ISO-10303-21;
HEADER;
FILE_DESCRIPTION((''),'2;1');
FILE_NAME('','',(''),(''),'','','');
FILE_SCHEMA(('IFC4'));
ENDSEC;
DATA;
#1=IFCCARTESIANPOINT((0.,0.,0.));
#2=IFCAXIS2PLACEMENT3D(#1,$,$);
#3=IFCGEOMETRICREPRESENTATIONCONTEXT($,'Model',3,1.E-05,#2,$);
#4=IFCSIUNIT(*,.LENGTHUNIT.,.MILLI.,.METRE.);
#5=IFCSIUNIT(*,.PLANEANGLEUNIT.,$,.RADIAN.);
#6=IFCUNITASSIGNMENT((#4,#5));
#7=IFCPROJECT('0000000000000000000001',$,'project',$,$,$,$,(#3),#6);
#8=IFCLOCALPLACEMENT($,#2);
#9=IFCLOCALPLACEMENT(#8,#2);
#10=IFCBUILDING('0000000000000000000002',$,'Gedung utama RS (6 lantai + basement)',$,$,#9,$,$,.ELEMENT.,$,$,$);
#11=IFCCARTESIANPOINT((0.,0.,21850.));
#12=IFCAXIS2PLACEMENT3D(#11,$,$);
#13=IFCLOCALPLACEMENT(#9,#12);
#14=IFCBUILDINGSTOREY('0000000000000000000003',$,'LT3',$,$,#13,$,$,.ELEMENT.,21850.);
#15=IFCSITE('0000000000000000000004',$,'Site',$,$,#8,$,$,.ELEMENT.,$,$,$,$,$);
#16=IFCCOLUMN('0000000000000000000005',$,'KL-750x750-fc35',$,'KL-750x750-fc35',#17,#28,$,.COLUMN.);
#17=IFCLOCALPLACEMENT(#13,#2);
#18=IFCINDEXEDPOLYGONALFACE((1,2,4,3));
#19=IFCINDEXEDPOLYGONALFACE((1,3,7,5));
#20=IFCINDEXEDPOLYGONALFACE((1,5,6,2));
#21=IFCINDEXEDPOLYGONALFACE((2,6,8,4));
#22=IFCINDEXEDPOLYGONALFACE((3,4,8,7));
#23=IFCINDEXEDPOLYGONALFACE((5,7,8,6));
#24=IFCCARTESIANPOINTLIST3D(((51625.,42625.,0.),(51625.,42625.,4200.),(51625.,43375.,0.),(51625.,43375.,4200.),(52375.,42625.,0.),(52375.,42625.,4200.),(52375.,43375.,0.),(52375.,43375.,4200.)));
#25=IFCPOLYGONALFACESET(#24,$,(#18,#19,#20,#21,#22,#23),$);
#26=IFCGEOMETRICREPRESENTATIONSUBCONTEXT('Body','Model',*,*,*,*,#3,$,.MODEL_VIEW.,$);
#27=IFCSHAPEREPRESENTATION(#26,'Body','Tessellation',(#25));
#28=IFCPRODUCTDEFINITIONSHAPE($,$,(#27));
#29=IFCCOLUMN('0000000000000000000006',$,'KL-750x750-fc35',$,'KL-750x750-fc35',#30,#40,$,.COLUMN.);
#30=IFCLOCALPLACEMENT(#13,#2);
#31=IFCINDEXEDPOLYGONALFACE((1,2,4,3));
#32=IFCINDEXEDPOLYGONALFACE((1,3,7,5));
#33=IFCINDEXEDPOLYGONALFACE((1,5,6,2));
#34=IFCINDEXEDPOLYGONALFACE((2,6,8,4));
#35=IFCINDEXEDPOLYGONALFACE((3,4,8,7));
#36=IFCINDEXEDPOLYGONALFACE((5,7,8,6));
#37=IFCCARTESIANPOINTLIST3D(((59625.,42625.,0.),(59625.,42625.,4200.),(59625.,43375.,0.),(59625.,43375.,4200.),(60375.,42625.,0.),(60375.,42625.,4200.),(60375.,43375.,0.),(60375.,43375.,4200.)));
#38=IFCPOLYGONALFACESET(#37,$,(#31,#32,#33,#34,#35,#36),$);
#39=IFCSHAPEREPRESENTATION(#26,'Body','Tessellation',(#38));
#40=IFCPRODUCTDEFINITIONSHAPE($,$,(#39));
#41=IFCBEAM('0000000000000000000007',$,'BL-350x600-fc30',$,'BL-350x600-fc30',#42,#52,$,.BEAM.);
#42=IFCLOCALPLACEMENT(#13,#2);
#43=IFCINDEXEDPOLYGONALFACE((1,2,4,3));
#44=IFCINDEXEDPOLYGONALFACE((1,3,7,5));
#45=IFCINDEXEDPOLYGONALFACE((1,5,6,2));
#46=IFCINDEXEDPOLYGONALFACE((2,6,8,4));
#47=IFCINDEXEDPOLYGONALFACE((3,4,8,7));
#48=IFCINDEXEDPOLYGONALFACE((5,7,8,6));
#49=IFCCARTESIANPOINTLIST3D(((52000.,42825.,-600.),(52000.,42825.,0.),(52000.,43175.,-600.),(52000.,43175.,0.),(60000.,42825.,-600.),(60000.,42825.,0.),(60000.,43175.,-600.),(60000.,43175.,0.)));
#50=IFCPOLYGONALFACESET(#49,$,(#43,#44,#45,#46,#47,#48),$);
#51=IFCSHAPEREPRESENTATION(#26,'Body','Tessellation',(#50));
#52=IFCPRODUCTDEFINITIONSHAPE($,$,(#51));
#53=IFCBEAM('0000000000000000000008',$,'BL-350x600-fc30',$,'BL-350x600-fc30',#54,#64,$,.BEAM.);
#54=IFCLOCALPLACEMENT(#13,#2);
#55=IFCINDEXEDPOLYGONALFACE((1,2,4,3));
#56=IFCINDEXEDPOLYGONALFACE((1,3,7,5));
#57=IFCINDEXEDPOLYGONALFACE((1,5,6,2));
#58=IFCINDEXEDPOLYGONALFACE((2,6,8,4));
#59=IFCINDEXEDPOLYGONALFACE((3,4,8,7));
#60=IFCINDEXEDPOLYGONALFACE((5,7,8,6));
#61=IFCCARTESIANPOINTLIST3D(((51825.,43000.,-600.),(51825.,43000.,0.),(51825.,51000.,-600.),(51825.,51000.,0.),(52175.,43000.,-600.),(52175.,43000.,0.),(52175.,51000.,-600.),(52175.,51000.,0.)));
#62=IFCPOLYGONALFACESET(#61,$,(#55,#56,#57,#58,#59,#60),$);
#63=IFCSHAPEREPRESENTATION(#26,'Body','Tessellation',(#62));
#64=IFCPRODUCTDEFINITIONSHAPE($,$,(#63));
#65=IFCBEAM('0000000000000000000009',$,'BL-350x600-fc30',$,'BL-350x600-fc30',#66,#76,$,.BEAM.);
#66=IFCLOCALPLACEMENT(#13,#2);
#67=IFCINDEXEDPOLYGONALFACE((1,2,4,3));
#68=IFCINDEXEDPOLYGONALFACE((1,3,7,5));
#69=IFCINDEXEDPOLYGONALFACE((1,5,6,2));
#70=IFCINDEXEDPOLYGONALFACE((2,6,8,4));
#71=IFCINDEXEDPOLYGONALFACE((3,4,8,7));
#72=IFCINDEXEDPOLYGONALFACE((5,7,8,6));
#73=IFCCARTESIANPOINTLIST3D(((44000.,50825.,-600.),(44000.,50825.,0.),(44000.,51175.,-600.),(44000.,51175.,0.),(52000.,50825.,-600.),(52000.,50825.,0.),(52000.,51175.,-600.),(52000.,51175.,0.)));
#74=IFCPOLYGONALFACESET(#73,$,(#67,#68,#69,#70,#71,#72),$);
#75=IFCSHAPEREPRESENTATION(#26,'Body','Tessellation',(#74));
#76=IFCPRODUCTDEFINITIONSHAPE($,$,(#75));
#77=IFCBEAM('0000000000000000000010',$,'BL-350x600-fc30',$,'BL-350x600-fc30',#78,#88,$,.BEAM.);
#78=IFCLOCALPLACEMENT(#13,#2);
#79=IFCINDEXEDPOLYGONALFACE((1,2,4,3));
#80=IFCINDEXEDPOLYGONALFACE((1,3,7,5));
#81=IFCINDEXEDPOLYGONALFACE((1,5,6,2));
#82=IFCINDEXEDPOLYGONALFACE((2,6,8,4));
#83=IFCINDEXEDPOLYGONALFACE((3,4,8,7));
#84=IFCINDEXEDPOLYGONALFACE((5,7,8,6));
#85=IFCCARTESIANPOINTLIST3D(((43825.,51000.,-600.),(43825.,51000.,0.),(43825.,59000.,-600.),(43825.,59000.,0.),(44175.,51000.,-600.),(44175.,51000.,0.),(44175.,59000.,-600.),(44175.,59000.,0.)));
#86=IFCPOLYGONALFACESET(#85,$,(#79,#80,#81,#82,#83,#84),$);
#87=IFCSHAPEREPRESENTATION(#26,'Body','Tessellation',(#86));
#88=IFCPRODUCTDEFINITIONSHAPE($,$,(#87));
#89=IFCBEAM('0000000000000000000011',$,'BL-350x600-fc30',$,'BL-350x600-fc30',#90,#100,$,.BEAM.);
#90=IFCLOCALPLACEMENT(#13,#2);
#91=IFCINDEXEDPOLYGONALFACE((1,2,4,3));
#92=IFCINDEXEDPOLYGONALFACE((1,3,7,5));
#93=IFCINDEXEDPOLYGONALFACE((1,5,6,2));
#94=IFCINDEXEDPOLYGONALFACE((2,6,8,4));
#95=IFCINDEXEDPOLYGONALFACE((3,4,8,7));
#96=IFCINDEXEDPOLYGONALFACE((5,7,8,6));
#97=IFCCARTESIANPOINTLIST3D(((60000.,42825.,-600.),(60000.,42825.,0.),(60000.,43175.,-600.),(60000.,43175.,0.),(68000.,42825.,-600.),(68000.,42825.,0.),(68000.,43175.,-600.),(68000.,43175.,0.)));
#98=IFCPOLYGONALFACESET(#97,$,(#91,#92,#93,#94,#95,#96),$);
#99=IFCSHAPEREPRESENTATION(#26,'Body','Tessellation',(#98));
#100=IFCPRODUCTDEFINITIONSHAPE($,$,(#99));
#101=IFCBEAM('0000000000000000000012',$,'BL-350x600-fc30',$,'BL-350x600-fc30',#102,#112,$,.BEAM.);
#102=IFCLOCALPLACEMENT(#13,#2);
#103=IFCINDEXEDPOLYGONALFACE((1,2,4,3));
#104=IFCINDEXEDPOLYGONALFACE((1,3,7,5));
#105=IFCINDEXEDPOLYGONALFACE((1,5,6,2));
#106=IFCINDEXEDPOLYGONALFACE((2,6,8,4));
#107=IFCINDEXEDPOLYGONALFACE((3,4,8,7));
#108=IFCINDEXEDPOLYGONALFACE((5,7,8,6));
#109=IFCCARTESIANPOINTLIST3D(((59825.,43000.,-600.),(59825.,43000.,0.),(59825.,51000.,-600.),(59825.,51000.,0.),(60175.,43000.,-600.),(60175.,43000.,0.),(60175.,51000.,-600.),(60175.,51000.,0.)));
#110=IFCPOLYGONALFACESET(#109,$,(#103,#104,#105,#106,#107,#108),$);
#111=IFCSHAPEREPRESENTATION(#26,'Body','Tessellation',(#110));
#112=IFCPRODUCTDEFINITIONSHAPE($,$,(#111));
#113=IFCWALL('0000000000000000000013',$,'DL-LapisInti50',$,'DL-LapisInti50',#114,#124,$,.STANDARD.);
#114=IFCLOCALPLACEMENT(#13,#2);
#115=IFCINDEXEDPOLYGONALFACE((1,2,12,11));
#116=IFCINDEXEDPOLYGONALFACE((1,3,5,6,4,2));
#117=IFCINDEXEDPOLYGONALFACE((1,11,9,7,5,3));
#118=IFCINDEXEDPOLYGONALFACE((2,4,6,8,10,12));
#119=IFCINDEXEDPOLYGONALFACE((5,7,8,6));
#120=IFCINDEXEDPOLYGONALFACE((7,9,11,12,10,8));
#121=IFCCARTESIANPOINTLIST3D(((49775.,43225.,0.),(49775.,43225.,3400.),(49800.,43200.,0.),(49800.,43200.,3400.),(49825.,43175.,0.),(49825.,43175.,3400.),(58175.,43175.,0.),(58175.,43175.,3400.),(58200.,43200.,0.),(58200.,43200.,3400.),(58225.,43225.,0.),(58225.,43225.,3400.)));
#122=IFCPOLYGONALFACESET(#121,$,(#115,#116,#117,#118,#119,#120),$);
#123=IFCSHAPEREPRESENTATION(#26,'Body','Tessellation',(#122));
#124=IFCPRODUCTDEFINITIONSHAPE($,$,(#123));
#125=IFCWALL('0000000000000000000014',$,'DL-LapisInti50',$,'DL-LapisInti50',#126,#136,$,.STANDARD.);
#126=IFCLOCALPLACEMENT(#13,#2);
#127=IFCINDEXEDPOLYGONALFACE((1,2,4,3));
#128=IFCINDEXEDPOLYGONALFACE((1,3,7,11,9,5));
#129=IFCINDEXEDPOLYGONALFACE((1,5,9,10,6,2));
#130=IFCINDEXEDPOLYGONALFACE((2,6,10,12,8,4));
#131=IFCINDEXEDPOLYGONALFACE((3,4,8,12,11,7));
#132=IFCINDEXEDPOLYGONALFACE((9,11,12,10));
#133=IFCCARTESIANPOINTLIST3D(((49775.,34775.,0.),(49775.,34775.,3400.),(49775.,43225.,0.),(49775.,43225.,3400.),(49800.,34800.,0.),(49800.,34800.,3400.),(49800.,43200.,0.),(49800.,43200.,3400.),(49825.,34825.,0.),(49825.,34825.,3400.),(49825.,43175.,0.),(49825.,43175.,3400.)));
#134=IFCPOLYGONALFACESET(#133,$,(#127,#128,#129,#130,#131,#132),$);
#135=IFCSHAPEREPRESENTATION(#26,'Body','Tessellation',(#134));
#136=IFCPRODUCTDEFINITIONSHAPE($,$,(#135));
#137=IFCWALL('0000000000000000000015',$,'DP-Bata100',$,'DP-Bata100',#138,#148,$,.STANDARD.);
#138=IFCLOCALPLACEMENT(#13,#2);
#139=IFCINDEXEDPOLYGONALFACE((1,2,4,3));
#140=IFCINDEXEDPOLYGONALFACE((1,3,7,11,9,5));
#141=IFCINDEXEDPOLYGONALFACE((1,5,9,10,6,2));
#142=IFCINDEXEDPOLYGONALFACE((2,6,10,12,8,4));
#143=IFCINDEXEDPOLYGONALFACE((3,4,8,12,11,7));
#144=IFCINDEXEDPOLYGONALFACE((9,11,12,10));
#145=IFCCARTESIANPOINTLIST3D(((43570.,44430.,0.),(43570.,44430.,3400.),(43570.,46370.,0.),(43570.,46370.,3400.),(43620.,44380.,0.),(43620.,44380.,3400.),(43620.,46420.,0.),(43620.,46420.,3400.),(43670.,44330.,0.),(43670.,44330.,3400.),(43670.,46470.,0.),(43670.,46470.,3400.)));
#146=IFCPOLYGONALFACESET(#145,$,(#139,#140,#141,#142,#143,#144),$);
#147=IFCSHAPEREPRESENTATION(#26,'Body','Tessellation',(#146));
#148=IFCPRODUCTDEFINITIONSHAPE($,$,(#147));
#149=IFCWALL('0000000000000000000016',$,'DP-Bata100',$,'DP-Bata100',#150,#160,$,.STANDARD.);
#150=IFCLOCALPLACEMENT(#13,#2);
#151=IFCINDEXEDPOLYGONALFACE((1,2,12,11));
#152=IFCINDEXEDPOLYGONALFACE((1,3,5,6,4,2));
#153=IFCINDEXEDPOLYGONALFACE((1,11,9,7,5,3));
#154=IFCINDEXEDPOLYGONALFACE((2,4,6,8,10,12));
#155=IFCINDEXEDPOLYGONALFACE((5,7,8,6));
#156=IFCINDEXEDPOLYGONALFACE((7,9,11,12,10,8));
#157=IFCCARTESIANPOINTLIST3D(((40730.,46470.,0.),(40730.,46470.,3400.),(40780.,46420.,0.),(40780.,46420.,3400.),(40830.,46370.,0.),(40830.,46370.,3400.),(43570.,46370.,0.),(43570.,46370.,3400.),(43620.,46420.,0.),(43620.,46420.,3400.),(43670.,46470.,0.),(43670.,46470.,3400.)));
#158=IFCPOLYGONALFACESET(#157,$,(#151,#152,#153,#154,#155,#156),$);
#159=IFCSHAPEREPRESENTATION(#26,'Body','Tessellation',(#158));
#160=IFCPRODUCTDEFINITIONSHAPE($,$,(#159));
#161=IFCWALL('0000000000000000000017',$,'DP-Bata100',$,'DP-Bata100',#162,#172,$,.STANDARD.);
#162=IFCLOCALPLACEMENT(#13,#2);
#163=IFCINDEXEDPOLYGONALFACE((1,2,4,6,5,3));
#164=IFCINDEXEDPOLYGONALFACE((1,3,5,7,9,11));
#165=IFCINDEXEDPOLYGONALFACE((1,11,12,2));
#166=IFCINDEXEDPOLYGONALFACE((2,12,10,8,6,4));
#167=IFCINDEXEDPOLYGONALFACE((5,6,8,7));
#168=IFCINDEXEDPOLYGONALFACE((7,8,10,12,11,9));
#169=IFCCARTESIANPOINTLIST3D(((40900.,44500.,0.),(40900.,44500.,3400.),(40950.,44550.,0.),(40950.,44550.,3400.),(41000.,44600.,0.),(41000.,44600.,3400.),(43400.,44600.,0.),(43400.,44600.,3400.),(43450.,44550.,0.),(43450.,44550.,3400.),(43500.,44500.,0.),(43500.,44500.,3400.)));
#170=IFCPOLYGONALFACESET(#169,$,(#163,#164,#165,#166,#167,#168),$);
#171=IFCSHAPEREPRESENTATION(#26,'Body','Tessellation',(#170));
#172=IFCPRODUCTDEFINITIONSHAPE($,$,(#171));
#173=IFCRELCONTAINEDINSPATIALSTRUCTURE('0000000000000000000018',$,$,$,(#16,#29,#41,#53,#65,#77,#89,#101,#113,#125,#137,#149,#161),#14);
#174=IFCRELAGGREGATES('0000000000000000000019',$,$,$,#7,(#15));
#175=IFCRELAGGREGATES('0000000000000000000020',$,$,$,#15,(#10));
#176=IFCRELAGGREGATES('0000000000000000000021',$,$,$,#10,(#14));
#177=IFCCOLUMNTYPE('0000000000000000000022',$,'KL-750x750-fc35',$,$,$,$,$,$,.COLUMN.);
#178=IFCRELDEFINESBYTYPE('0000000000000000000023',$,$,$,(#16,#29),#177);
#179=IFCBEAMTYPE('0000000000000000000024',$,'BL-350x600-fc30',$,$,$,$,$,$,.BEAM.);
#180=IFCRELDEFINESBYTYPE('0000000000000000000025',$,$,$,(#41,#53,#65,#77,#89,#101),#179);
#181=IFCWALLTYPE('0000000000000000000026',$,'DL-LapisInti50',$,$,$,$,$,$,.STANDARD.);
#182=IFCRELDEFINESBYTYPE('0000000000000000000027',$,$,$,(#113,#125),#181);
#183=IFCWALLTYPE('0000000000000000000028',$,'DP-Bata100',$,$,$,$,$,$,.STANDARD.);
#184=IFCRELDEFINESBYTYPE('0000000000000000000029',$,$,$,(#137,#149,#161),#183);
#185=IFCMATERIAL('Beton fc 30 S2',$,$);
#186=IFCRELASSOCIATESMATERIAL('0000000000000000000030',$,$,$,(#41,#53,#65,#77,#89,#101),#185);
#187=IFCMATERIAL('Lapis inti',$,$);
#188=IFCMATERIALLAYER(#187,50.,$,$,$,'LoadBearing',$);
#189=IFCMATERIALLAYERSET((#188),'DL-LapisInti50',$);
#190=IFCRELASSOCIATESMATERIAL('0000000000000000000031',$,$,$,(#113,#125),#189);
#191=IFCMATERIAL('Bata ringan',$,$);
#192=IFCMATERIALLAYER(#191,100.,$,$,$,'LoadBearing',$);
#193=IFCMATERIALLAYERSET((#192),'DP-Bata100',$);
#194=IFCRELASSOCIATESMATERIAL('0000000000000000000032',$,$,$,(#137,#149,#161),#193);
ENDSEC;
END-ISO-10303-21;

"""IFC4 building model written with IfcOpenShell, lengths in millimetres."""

from ifc_helpers import new_model, si_unit, frame, origin, origin_2d, place, context, subcontext, project, spatial, polyline, rectangle, outline, extrude, material, layer, layer_set, layer_usage, material_profile, profile_set, profile_usage, type_object, element, save


model = new_model("IFC4")

# Units and contexts
model_context = context("Model", 3, precision=1e-05, world=origin())
body_context = subcontext(model_context, "Body", "Model", "MODEL_VIEW")
ifc_project = project(units=[si_unit("LENGTHUNIT", "METRE", prefix="MILLI"), si_unit("PLANEANGLEUNIT", "RADIAN")], contexts=[model_context])

# Site, building, storey
site_placement = place(None, origin())
site = spatial("IfcSite", under=ifc_project, at=site_placement, Name="Site", CompositionType="ELEMENT")
building_placement = place(site_placement, origin())
building = spatial("IfcBuilding", under=site, at=building_placement, Name="Gedung utama RS (6 lantai + basement)", CompositionType="ELEMENT")
storey_placement = place(building_placement, frame((0.0, 0.0, 21850.0)))
storey = spatial("IfcBuildingStorey", under=building, at=storey_placement, Name="LT3", CompositionType="ELEMENT", Elevation=21850.0)

# Columns
ifc_material_profile_1 = material_profile(None, rectangle(XDim=750.0, YDim=750.0, at=origin_2d()), Name="KL-750x750-fc35")
ifc_profile_set_1 = profile_set([ifc_material_profile_1], Name="KL-750x750-fc35")
ifc_profile_usage_1 = profile_usage(ifc_profile_set_1, cardinal=5)
column_type = type_object("IfcColumnType", Name="KL-750x750-fc35", PredefinedType="COLUMN")
for number, where, z_axis, x_axis, name in (
    (1, (52000.0, 43000.0, 0.0), (0.0, 0.0, 1.0), (1.0, 0.0, 0.0), "KL-750x750-fc35"),
    (2, (60000.0, 43000.0, 0.0), (0.0, 0.0, 1.0), (1.0, 0.0, 0.0), "KL-750x750-fc35"),
):
    element("IfcColumn", number, at=place(storey_placement, frame(where, z_axis=z_axis, x_axis=x_axis)), inside=storey, type_object=column_type, material=ifc_profile_usage_1, Name=name, ObjectType="KL-750x750-fc35", PredefinedType="COLUMN", context=body_context, shape_type="SweptSolid", body=[
        extrude(rectangle(XDim=750.0, YDim=750.0, at=origin_2d()), origin(), (0.0, 0.0, 1.0), 4200.0),
    ])

# Beams
ifc_material_1 = material(Name="Beton fc 30 S2")
ifc_material_profile_2 = material_profile(ifc_material_1, rectangle(XDim=350.0, YDim=600.0, at=origin_2d()), Name="BL-350x600-fc30")
ifc_profile_set_2 = profile_set([ifc_material_profile_2], Name="BL-350x600-fc30")
ifc_profile_usage_2 = profile_usage(ifc_profile_set_2, cardinal=8)
beam_type = type_object("IfcBeamType", Name="BL-350x600-fc30", PredefinedType="BEAM")
beam_1_placement = place(storey_placement, frame((52000.0, 43000.0, -300.0)))
element("IfcBeam", 3, at=beam_1_placement, inside=storey, type_object=beam_type, material=ifc_profile_usage_2, Name="BL-350x600-fc30", ObjectType="BL-350x600-fc30", PredefinedType="BEAM", context=body_context, shape_type="SweptSolid", body=[
    extrude(rectangle(XDim=350.0, YDim=600.0, at=origin_2d()), frame((0.0, 0.0, 0.0), z_axis=(1.0, 0.0, 0.0), x_axis=(0.0, 1.0, 0.0)), (0.0, 0.0, 1.0), 8000.0),
])
beam_2_placement = place(storey_placement, frame((52000.0, 43000.0, -300.0)))
element("IfcBeam", 4, at=beam_2_placement, inside=storey, type_object=beam_type, material=ifc_profile_usage_2, Name="BL-350x600-fc30", ObjectType="BL-350x600-fc30", PredefinedType="BEAM", context=body_context, shape_type="SweptSolid", body=[
    extrude(rectangle(XDim=350.0, YDim=600.0, at=origin_2d()), frame((0.0, 0.0, 0.0), z_axis=(0.0, 1.0, 0.0), x_axis=(-1.0, 0.0, 0.0)), (0.0, 0.0, 1.0), 8000.0),
])
beam_3_placement = place(storey_placement, frame((44000.0, 51000.0, -300.0)))
element("IfcBeam", 5, at=beam_3_placement, inside=storey, type_object=beam_type, material=ifc_profile_usage_2, Name="BL-350x600-fc30", ObjectType="BL-350x600-fc30", PredefinedType="BEAM", context=body_context, shape_type="SweptSolid", body=[
    extrude(rectangle(XDim=350.0, YDim=600.0, at=origin_2d()), frame((0.0, 0.0, 0.0), z_axis=(1.0, 0.0, 0.0), x_axis=(0.0, 1.0, 0.0)), (0.0, 0.0, 1.0), 8000.0),
])
beam_4_placement = place(storey_placement, frame((44000.0, 51000.0, -300.0)))
element("IfcBeam", 6, at=beam_4_placement, inside=storey, type_object=beam_type, material=ifc_profile_usage_2, Name="BL-350x600-fc30", ObjectType="BL-350x600-fc30", PredefinedType="BEAM", context=body_context, shape_type="SweptSolid", body=[
    extrude(rectangle(XDim=350.0, YDim=600.0, at=origin_2d()), frame((0.0, 0.0, 0.0), z_axis=(0.0, 1.0, 0.0), x_axis=(-1.0, 0.0, 0.0)), (0.0, 0.0, 1.0), 8000.0),
])
beam_5_placement = place(storey_placement, frame((60000.0, 43000.0, -300.0)))
element("IfcBeam", 7, at=beam_5_placement, inside=storey, type_object=beam_type, material=ifc_profile_usage_2, Name="BL-350x600-fc30", ObjectType="BL-350x600-fc30", PredefinedType="BEAM", context=body_context, shape_type="SweptSolid", body=[
    extrude(rectangle(XDim=350.0, YDim=600.0, at=origin_2d()), frame((0.0, 0.0, 0.0), z_axis=(1.0, 0.0, 0.0), x_axis=(0.0, 1.0, 0.0)), (0.0, 0.0, 1.0), 8000.0),
])
beam_6_placement = place(storey_placement, frame((60000.0, 43000.0, -300.0)))
element("IfcBeam", 8, at=beam_6_placement, inside=storey, type_object=beam_type, material=ifc_profile_usage_2, Name="BL-350x600-fc30", ObjectType="BL-350x600-fc30", PredefinedType="BEAM", context=body_context, shape_type="SweptSolid", body=[
    extrude(rectangle(XDim=350.0, YDim=600.0, at=origin_2d()), frame((0.0, 0.0, 0.0), z_axis=(0.0, 1.0, 0.0), x_axis=(-1.0, 0.0, 0.0)), (0.0, 0.0, 1.0), 8000.0),
])

# Walls
ifc_material_2 = material(Name="Lapis inti")
ifc_layer_1 = layer(ifc_material_2, 50.0, Category="LoadBearing")
ifc_layer_set_1 = layer_set([ifc_layer_1], Name="DL-LapisInti50")
ifc_layer_usage_1 = layer_usage(ifc_layer_set_1, "AXIS2", "NEGATIVE", 25.0)
wall_type_1 = type_object("IfcWallType", Name="DL-LapisInti50", PredefinedType="STANDARD")
for number, where, z_axis, x_axis, name in (
    (9, (58200.0, 43200.0, 0.0), (0.0, 0.0, 1.0), (-1.0, 0.0, 0.0), "DL-LapisInti50"),
    (10, (49800.0, 43200.0, 0.0), (0.0, 0.0, 1.0), (0.0, -1.0, 0.0), "DL-LapisInti50"),
):
    element("IfcWall", number, at=place(storey_placement, frame(where, z_axis=z_axis, x_axis=x_axis)), inside=storey, type_object=wall_type_1, material=ifc_layer_usage_1, Name=name, ObjectType="DL-LapisInti50", PredefinedType="STANDARD", context=body_context, shape_type="SweptSolid", body=[
        extrude(outline(polyline([(-25.0, -25.0), (0.0, 0.0), (25.0, 25.0), (8375.0, 25.0), (8400.0, 0.0), (8425.0, -25.0), (-25.0, -25.0)])), origin(), (0.0, 0.0, 1.0), 3400.0),
    ])
ifc_material_3 = material(Name="Bata ringan")
ifc_layer_2 = layer(ifc_material_3, 100.0, Category="LoadBearing")
ifc_layer_set_2 = layer_set([ifc_layer_2], Name="DP-Bata100")
ifc_layer_usage_2 = layer_usage(ifc_layer_set_2, "AXIS2", "NEGATIVE", 50.0)
wall_type_2 = type_object("IfcWallType", Name="DP-Bata100", PredefinedType="STANDARD")
wall_1_placement = place(storey_placement, frame((43620.0, 44380.0, 0.0), z_axis=(0.0, 0.0, 1.0), x_axis=(0.0, 1.0, 0.0)))
element("IfcWall", 11, at=wall_1_placement, inside=storey, type_object=wall_type_2, material=ifc_layer_usage_2, Name="DP-Bata100", ObjectType="DP-Bata100", PredefinedType="STANDARD", context=body_context, shape_type="SweptSolid", body=[
    extrude(outline(polyline([(-50.0, -50.0), (0.0, 0.0), (50.0, 50.0), (1990.0, 50.0), (2040.0, 0.0), (2090.0, -50.0), (-50.0, -50.0)])), origin(), (0.0, 0.0, 1.0), 3400.0),
])
wall_2_placement = place(storey_placement, frame((43620.0, 46420.0, 0.0), z_axis=(0.0, 0.0, 1.0), x_axis=(-1.0, 0.0, 0.0)))
element("IfcWall", 12, at=wall_2_placement, inside=storey, type_object=wall_type_2, material=ifc_layer_usage_2, Name="DP-Bata100", ObjectType="DP-Bata100", PredefinedType="STANDARD", context=body_context, shape_type="SweptSolid", body=[
    extrude(outline(polyline([(-50.0, -50.0), (0.0, 0.0), (50.0, 50.0), (2790.0, 50.0), (2840.0, 0.0), (2890.0, -50.0), (-50.0, -50.0)])), origin(), (0.0, 0.0, 1.0), 3400.0),
])
for number, where, z_axis, x_axis, name in (
    (13, (43450.0, 44550.0, 0.0), (0.0, 0.0, 1.0), (-1.0, 0.0, 0.0), "DP-Bata100"),
):
    element("IfcWall", number, at=place(storey_placement, frame(where, z_axis=z_axis, x_axis=x_axis)), inside=storey, type_object=wall_type_2, material=ifc_layer_usage_2, Name=name, ObjectType="DP-Bata100", PredefinedType="STANDARD", context=body_context, shape_type="SweptSolid", body=[
        extrude(outline(polyline([(50.0, -50.0), (0.0, 0.0), (-50.0, 50.0), (2550.0, 50.0), (2500.0, 0.0), (2450.0, -50.0), (50.0, -50.0)])), origin(), (0.0, 0.0, 1.0), 3400.0),
    ])

save(model, "model.ifc")
